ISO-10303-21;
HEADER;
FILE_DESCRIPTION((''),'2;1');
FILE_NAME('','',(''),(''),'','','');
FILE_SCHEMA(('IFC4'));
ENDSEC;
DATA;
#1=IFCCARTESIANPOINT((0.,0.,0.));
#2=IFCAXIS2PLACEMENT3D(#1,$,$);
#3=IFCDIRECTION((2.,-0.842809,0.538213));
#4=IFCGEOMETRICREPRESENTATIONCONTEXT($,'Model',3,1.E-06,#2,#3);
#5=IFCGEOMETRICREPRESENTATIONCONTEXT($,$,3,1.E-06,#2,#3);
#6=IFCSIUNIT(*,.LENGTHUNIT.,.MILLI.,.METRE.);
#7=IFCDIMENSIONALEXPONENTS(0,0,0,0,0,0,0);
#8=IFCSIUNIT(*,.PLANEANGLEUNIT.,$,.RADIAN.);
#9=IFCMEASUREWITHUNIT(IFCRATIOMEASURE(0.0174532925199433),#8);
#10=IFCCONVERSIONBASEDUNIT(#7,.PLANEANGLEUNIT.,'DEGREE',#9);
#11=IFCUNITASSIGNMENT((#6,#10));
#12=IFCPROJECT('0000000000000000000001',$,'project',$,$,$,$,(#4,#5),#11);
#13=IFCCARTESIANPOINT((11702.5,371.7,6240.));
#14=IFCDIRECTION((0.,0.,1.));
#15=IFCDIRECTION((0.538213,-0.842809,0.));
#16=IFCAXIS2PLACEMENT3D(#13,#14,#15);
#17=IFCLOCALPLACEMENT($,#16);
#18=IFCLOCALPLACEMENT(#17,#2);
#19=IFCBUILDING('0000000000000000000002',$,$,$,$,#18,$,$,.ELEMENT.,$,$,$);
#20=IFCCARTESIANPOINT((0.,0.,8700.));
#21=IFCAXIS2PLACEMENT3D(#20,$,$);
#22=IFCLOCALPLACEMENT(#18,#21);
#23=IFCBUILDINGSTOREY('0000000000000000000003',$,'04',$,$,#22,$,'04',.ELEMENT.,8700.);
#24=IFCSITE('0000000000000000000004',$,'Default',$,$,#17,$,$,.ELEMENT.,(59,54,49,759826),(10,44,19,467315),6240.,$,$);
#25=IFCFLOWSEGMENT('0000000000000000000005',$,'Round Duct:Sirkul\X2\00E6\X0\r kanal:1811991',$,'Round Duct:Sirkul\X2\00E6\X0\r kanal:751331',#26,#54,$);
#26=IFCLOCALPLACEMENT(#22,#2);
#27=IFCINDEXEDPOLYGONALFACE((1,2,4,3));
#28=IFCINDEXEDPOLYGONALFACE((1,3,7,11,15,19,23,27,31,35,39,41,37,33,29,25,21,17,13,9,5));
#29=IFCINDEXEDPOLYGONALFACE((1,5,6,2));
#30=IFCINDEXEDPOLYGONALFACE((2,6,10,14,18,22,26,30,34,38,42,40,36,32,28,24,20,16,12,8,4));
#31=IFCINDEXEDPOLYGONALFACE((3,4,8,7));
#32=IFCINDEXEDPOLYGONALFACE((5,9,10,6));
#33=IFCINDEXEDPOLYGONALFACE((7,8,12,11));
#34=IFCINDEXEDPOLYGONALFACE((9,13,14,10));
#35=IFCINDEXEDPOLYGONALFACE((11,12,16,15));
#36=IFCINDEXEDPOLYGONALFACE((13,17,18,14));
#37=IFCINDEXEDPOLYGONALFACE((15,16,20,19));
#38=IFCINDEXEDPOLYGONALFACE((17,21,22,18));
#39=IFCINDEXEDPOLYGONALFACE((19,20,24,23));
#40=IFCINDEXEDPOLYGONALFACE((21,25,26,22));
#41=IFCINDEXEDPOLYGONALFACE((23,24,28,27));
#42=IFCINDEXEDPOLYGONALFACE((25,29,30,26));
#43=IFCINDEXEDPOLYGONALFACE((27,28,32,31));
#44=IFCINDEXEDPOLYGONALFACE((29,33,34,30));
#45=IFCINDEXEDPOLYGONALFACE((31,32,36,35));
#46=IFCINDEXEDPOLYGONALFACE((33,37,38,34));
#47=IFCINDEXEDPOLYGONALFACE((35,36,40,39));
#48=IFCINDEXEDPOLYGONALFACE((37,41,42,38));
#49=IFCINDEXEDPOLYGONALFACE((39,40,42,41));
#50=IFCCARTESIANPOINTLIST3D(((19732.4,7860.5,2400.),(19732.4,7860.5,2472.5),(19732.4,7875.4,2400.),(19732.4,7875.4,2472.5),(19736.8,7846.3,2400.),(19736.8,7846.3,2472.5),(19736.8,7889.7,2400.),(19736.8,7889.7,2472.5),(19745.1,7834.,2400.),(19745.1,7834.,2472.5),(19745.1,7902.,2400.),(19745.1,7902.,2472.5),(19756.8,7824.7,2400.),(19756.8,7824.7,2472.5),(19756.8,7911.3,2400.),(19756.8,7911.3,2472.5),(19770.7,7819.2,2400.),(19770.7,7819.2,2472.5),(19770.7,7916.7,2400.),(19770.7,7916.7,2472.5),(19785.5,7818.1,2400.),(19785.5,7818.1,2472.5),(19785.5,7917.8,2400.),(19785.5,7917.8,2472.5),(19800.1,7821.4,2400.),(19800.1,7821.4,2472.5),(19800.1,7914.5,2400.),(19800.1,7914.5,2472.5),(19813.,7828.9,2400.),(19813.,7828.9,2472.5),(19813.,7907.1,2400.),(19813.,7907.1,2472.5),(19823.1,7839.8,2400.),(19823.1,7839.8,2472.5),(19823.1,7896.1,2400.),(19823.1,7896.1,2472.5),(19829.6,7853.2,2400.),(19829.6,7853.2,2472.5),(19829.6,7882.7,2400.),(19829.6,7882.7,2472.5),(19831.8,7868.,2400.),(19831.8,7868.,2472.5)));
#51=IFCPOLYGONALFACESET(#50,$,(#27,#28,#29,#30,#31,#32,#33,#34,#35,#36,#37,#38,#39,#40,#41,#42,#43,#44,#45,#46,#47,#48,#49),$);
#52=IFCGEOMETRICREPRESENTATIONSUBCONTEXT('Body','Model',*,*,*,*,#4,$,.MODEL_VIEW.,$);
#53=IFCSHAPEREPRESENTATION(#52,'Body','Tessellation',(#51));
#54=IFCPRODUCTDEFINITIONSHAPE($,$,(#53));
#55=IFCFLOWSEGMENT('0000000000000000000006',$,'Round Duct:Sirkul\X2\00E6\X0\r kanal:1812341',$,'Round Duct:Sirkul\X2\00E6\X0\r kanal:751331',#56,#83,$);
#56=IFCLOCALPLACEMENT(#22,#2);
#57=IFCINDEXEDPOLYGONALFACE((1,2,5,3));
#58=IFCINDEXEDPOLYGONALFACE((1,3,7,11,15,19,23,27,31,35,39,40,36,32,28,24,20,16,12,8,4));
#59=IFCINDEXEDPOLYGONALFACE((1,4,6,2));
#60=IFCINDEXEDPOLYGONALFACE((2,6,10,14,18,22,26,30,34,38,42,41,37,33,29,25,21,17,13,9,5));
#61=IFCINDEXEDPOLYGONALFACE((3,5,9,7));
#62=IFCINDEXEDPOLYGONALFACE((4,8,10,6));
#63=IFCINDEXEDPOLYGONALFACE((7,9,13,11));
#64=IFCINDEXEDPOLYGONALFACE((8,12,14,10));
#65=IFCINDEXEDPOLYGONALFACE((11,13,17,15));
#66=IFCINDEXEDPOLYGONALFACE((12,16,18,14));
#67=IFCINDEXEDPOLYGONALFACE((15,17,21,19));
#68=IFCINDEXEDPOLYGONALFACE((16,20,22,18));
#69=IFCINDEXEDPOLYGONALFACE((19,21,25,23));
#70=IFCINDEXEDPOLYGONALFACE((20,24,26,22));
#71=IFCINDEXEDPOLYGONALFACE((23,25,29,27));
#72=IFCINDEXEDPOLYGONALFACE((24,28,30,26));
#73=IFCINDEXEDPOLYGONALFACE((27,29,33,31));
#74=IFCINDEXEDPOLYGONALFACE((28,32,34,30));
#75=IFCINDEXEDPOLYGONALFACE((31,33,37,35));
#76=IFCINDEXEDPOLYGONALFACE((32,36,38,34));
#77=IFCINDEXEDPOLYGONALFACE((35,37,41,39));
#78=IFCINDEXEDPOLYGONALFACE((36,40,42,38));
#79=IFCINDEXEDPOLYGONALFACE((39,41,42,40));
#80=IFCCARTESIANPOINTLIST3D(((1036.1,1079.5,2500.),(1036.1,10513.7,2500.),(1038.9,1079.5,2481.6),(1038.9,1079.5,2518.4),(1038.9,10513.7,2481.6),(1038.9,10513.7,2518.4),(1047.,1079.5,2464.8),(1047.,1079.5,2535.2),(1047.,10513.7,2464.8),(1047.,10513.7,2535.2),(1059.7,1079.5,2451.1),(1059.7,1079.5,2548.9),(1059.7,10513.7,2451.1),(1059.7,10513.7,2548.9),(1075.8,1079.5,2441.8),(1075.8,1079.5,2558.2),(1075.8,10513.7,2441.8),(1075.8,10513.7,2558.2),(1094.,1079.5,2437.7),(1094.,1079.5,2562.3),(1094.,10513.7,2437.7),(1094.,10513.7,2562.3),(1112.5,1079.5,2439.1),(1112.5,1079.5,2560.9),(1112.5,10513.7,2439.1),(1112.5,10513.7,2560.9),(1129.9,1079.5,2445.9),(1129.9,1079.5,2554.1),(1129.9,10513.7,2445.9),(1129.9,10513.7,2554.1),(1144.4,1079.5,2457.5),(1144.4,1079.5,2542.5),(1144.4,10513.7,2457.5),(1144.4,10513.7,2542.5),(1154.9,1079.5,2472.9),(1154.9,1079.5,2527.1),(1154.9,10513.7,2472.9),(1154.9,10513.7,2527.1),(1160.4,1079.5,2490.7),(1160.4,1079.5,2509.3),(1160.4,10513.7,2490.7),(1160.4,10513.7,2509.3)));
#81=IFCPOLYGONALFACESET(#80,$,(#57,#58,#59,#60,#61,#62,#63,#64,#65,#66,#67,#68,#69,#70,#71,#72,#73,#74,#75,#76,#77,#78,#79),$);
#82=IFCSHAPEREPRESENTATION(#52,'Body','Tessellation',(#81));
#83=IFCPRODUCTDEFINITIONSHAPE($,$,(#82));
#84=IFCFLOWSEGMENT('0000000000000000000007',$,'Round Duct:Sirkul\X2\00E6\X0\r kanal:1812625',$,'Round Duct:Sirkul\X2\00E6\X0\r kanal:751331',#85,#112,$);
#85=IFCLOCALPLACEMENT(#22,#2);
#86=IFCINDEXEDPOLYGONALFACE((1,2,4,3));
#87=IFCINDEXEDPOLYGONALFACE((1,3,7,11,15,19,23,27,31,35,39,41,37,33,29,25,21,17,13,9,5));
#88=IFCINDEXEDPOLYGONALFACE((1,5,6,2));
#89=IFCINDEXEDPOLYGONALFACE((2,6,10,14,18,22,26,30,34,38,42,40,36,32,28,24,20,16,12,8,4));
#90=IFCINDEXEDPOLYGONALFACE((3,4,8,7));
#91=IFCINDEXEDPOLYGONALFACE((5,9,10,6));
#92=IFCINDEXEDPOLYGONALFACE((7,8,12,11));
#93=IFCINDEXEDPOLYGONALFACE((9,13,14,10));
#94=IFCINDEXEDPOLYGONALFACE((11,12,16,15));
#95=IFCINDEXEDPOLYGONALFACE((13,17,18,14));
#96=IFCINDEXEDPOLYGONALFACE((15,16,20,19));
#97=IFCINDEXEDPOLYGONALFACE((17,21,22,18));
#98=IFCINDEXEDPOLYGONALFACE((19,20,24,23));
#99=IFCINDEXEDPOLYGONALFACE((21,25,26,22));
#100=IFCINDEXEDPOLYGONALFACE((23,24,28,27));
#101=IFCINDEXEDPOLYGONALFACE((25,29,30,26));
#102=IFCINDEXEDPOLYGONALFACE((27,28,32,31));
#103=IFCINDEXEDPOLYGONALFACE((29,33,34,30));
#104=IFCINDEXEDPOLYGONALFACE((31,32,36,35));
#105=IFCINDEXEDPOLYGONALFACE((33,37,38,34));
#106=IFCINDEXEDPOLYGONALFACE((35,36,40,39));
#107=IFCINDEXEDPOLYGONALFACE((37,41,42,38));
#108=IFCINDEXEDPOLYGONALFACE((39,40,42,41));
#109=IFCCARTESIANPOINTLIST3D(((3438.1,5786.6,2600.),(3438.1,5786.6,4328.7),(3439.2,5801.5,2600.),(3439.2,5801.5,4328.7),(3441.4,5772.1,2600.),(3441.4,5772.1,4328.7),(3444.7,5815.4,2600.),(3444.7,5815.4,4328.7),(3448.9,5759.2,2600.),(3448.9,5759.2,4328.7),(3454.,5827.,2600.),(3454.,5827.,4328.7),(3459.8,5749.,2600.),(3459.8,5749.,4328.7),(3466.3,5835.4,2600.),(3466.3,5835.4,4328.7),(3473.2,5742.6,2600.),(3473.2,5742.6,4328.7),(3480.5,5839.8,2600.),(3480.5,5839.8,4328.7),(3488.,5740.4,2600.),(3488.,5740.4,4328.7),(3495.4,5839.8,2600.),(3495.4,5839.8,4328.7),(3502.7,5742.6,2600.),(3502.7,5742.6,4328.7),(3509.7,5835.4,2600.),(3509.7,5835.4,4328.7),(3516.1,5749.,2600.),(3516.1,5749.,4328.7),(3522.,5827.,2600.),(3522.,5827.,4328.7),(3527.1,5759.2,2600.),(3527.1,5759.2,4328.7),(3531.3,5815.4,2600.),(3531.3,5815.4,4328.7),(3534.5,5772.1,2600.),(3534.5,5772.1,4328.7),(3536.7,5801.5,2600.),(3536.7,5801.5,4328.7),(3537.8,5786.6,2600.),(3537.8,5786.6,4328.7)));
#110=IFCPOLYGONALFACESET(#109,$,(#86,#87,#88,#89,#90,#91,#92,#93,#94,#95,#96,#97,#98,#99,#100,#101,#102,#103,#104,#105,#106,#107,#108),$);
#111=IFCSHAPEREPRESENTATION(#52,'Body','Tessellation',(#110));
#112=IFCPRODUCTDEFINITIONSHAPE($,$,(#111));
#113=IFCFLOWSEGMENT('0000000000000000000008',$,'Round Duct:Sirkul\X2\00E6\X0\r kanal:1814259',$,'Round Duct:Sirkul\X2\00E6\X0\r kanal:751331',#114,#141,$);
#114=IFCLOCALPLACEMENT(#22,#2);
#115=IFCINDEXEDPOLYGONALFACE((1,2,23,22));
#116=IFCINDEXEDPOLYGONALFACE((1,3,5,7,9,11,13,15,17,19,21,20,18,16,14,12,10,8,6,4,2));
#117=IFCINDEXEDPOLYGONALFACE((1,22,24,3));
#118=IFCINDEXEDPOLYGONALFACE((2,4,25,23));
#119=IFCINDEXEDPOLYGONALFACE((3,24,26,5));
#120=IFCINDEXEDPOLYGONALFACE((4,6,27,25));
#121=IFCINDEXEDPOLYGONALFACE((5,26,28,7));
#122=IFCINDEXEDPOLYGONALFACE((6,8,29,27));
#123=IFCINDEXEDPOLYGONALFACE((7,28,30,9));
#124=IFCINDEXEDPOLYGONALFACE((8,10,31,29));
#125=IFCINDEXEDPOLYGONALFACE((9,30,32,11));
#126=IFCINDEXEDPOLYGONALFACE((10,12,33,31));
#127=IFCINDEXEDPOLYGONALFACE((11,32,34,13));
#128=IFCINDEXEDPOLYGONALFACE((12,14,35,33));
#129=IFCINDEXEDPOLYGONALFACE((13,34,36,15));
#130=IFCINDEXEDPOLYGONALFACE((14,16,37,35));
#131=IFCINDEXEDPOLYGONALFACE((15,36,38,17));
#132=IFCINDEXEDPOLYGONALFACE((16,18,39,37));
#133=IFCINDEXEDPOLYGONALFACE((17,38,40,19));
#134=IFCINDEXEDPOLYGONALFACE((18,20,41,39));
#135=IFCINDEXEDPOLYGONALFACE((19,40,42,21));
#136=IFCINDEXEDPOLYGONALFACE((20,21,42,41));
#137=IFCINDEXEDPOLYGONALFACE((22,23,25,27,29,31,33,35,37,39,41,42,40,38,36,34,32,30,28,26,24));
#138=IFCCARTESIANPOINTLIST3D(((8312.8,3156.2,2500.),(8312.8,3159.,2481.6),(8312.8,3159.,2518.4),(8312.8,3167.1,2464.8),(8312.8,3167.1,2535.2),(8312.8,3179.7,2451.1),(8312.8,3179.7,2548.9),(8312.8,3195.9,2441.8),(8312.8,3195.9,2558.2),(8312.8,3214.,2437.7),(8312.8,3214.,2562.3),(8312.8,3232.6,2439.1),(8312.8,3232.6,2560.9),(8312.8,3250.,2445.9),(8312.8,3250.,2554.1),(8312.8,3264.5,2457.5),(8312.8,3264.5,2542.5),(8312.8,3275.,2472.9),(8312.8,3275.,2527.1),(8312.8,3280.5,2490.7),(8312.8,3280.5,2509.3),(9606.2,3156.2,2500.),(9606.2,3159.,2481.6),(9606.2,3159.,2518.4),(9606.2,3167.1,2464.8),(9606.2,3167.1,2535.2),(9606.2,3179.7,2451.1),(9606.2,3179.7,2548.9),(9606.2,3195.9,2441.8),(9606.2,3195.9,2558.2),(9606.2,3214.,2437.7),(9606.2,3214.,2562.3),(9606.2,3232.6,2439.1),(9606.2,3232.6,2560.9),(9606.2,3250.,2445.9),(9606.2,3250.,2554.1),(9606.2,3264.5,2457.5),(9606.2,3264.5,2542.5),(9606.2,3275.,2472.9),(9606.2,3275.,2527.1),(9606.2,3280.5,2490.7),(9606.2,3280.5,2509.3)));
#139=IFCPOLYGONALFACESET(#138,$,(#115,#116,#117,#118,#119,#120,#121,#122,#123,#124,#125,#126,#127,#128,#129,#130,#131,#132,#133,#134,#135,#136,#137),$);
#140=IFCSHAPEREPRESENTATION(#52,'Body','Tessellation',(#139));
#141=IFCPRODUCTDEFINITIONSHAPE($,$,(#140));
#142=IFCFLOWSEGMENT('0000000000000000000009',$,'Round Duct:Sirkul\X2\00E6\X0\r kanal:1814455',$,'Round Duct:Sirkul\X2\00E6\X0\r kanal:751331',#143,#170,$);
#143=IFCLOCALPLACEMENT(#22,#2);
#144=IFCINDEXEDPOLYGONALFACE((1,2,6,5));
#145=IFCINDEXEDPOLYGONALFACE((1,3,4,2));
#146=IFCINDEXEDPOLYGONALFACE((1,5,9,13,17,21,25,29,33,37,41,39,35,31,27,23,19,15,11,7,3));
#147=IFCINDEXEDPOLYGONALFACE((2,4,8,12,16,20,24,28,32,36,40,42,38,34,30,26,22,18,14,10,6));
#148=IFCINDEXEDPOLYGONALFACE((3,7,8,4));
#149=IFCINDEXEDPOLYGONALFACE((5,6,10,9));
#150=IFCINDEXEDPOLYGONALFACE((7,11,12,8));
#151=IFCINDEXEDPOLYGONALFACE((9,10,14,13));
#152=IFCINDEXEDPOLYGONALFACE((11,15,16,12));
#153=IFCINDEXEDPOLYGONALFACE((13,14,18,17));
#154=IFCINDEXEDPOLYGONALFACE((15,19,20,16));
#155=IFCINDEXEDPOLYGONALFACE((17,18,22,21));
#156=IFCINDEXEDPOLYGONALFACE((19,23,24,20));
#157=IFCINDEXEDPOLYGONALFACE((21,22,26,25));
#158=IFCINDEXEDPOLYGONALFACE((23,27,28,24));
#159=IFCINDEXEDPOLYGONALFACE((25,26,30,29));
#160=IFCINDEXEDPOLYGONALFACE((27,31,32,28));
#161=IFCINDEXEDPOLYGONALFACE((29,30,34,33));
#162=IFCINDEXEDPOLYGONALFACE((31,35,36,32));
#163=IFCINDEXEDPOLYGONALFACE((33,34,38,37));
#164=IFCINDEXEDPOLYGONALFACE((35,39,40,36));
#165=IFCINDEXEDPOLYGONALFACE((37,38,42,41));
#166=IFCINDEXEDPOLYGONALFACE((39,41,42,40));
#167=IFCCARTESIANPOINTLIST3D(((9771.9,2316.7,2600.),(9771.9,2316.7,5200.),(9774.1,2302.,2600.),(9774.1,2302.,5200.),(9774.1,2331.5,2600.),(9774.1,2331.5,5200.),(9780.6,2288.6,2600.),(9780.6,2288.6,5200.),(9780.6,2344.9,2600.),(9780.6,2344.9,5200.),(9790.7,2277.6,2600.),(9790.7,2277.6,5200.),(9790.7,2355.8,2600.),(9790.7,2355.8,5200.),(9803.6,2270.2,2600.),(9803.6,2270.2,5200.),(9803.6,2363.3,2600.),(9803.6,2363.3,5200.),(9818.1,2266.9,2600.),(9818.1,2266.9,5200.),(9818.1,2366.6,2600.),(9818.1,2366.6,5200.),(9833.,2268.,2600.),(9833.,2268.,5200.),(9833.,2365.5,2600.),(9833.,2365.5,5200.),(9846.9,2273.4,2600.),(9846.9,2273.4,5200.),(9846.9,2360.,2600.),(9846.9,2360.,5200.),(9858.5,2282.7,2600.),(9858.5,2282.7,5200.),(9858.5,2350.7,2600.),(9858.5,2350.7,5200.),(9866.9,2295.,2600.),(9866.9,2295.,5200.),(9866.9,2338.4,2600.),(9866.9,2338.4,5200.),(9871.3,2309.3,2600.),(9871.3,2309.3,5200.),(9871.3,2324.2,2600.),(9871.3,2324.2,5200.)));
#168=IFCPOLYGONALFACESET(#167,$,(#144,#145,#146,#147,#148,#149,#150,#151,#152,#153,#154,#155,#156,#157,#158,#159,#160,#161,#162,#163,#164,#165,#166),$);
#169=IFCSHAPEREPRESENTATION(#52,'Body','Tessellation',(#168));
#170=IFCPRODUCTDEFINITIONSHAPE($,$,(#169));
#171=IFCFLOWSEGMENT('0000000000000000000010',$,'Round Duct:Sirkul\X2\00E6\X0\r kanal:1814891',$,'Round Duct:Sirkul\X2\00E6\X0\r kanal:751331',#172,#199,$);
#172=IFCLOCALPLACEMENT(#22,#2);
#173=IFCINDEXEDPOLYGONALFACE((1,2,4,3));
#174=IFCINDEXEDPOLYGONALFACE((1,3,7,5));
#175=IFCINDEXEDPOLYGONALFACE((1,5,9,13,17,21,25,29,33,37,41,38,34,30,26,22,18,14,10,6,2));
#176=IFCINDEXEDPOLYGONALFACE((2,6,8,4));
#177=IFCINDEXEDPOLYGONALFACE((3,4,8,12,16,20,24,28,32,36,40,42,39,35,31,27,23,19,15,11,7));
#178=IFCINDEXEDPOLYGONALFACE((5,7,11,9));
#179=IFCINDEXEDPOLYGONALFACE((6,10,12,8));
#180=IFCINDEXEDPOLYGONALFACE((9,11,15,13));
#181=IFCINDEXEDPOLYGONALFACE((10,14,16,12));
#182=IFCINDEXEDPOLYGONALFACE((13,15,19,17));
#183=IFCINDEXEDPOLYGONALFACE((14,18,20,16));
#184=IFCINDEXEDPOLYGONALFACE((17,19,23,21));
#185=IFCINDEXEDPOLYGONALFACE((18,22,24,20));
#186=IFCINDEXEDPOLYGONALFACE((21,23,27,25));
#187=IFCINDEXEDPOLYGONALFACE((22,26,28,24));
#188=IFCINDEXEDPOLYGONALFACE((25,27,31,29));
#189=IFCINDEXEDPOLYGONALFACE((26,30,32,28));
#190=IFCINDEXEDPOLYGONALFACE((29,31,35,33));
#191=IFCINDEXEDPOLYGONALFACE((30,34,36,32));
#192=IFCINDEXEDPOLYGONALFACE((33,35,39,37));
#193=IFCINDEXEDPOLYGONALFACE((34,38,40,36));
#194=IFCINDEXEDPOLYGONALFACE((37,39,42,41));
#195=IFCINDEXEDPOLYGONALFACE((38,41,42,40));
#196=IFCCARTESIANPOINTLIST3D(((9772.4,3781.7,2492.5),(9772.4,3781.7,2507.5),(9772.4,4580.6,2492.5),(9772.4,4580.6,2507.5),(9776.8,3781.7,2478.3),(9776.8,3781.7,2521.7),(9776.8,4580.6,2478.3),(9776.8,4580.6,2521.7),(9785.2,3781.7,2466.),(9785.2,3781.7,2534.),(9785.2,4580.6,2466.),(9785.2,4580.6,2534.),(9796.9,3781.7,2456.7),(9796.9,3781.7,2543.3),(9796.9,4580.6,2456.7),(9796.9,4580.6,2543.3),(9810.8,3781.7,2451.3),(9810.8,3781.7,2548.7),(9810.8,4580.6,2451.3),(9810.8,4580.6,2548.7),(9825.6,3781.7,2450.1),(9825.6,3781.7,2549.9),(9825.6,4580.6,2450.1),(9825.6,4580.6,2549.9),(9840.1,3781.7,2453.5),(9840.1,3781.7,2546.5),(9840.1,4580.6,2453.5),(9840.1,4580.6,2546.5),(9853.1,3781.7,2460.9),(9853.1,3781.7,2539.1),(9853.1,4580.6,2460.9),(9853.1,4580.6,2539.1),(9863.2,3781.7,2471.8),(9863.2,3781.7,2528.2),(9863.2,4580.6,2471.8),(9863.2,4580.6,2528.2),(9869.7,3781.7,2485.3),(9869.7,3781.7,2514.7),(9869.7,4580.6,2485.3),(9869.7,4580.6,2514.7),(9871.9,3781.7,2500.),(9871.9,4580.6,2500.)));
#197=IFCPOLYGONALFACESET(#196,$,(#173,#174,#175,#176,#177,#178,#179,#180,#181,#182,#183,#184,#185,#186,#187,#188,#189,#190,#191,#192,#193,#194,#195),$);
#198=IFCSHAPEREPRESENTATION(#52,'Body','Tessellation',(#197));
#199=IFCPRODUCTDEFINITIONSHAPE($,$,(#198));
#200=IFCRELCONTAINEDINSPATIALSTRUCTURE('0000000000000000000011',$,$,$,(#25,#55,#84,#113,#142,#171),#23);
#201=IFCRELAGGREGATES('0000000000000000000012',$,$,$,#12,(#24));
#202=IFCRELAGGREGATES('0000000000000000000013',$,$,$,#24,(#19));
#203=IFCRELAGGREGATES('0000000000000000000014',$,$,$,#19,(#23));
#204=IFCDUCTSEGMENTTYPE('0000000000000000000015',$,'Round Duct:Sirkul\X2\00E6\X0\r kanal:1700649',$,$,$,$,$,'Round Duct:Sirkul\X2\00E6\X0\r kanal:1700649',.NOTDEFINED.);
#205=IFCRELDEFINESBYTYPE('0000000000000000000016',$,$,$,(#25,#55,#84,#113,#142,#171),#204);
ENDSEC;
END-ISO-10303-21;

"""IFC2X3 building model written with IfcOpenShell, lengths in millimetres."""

from ifc_helpers import new_model, entity, si_unit, converted_unit, direction, frame, frame_2d, origin, origin_2d_with_axis, place, context, subcontext, project, spatial, circle, extrude, type_object, element, save


model = new_model("IFC2X3")

# Units and contexts
model_context = context("Model", 3, precision=1e-06, world=origin(), true_north=direction((2.0, -0.842809, 0.538213)))
context_of_model = context(None, 3, precision=1e-06, world=origin(), true_north=direction((2.0, -0.842809, 0.538213)))
body_context = subcontext(model_context, "Body", "Model", "MODEL_VIEW")
ifc_project = project(units=[si_unit("LENGTHUNIT", "METRE", prefix="MILLI"), converted_unit("PLANEANGLEUNIT", "DEGREE", entity("IfcRatioMeasure", 0.0174532925199433), si_unit("PLANEANGLEUNIT", "RADIAN"), dimensions=[0, 0, 0, 0, 0, 0, 0])], contexts=[model_context, context_of_model])

# Site, building, storey
site_placement = place(None, frame((11702.5, 371.7, 6240.0), z_axis=(0.0, 0.0, 1.0), x_axis=(0.538213, -0.842809, 0.0)))
site = spatial("IfcSite", under=ifc_project, at=site_placement, Name="Default", CompositionType="ELEMENT", RefLatitude=(59, 54, 49, 759826), RefLongitude=(10, 44, 19, 467315), RefElevation=6240.0)
building_placement = place(site_placement, origin())
building = spatial("IfcBuilding", under=site, at=building_placement, CompositionType="ELEMENT")
storey_placement = place(building_placement, frame((0.0, 0.0, 8700.0)))
storey = spatial("IfcBuildingStorey", under=building, at=storey_placement, Name="04", LongName="04", CompositionType="ELEMENT", Elevation=8700.0)

# Flow segments
duct_segment_type_1 = type_object("IfcDuctSegmentType", Name="Round Duct:Sirkulær kanal:1700649", ElementType="Round Duct:Sirkulær kanal:1700649", PredefinedType="NOTDEFINED")
flow_segment_1_placement = place(storey_placement, origin())
element("IfcFlowSegment", 1, at=flow_segment_1_placement, inside=storey, type_object=duct_segment_type_1, Name="Round Duct:Sirkulær kanal:1811991", ObjectType="Round Duct:Sirkulær kanal:751331", context=body_context, shape_type="SweptSolid", body=[
    extrude(circle(Radius=50.0, at=origin_2d_with_axis()), frame((19781.8, 7868.0, 2400.0)), (0.0, 0.0, 1.0), 72.5),
])
flow_segment_2_placement = place(storey_placement, origin())
element("IfcFlowSegment", 2, at=flow_segment_2_placement, inside=storey, type_object=duct_segment_type_1, Name="Round Duct:Sirkulær kanal:1812341", ObjectType="Round Duct:Sirkulær kanal:751331", context=body_context, shape_type="SweptSolid", body=[
    extrude(circle(Radius=62.5, at=frame_2d((0.0, 0.0), x_axis=(1.0, 0.0))), frame((1098.6, 1079.5, 2500.0), z_axis=(0.0, 1.0, 0.0), x_axis=(-1.0, 0.0, 0.0)), (0.0, 0.0, 1.0), 9434.3),
])
flow_segment_3_placement = place(storey_placement, origin())
element("IfcFlowSegment", 3, at=flow_segment_3_placement, inside=storey, type_object=duct_segment_type_1, Name="Round Duct:Sirkulær kanal:1812625", ObjectType="Round Duct:Sirkulær kanal:751331", context=body_context, shape_type="SweptSolid", body=[
    extrude(circle(Radius=50.0, at=origin_2d_with_axis()), frame((3488.0, 5790.4, 2600.0), z_axis=(0.0, 0.0, 1.0), x_axis=(0.0, -1.0, 0.0)), (0.0, 0.0, 1.0), 1728.7),
])
flow_segment_4_placement = place(storey_placement, origin())
element("IfcFlowSegment", 4, at=flow_segment_4_placement, inside=storey, type_object=duct_segment_type_1, Name="Round Duct:Sirkulær kanal:1814259", ObjectType="Round Duct:Sirkulær kanal:751331", context=body_context, shape_type="SweptSolid", body=[
    extrude(circle(Radius=62.5, at=frame_2d((0.0, 0.0), x_axis=(1.0, 0.0))), frame((8312.8, 3218.7, 2500.0), z_axis=(1.0, 0.0, 0.0), x_axis=(0.0, -1.0, 0.0)), (0.0, 0.0, 1.0), 1293.4),
])
flow_segment_5_placement = place(storey_placement, origin())
element("IfcFlowSegment", 5, at=flow_segment_5_placement, inside=storey, type_object=duct_segment_type_1, Name="Round Duct:Sirkulær kanal:1814455", ObjectType="Round Duct:Sirkulær kanal:751331", context=body_context, shape_type="SweptSolid", body=[
    extrude(circle(Radius=50.0, at=origin_2d_with_axis()), frame((9821.9, 2316.7, 2600.0), z_axis=(0.0, 0.0, 1.0), x_axis=(-1.0, 0.0, 0.0)), (0.0, 0.0, 1.0), 2600.0),
])
flow_segment_6_placement = place(storey_placement, origin())
element("IfcFlowSegment", 6, at=flow_segment_6_placement, inside=storey, type_object=duct_segment_type_1, Name="Round Duct:Sirkulær kanal:1814891", ObjectType="Round Duct:Sirkulær kanal:751331", context=body_context, shape_type="SweptSolid", body=[
    extrude(circle(Radius=50.0, at=origin_2d_with_axis()), frame((9821.9, 3781.7, 2500.0), z_axis=(0.0, 1.0, 0.0), x_axis=(1.0, 0.0, 0.0)), (0.0, 0.0, 1.0), 798.9),
])

save(model, "model.ifc")
